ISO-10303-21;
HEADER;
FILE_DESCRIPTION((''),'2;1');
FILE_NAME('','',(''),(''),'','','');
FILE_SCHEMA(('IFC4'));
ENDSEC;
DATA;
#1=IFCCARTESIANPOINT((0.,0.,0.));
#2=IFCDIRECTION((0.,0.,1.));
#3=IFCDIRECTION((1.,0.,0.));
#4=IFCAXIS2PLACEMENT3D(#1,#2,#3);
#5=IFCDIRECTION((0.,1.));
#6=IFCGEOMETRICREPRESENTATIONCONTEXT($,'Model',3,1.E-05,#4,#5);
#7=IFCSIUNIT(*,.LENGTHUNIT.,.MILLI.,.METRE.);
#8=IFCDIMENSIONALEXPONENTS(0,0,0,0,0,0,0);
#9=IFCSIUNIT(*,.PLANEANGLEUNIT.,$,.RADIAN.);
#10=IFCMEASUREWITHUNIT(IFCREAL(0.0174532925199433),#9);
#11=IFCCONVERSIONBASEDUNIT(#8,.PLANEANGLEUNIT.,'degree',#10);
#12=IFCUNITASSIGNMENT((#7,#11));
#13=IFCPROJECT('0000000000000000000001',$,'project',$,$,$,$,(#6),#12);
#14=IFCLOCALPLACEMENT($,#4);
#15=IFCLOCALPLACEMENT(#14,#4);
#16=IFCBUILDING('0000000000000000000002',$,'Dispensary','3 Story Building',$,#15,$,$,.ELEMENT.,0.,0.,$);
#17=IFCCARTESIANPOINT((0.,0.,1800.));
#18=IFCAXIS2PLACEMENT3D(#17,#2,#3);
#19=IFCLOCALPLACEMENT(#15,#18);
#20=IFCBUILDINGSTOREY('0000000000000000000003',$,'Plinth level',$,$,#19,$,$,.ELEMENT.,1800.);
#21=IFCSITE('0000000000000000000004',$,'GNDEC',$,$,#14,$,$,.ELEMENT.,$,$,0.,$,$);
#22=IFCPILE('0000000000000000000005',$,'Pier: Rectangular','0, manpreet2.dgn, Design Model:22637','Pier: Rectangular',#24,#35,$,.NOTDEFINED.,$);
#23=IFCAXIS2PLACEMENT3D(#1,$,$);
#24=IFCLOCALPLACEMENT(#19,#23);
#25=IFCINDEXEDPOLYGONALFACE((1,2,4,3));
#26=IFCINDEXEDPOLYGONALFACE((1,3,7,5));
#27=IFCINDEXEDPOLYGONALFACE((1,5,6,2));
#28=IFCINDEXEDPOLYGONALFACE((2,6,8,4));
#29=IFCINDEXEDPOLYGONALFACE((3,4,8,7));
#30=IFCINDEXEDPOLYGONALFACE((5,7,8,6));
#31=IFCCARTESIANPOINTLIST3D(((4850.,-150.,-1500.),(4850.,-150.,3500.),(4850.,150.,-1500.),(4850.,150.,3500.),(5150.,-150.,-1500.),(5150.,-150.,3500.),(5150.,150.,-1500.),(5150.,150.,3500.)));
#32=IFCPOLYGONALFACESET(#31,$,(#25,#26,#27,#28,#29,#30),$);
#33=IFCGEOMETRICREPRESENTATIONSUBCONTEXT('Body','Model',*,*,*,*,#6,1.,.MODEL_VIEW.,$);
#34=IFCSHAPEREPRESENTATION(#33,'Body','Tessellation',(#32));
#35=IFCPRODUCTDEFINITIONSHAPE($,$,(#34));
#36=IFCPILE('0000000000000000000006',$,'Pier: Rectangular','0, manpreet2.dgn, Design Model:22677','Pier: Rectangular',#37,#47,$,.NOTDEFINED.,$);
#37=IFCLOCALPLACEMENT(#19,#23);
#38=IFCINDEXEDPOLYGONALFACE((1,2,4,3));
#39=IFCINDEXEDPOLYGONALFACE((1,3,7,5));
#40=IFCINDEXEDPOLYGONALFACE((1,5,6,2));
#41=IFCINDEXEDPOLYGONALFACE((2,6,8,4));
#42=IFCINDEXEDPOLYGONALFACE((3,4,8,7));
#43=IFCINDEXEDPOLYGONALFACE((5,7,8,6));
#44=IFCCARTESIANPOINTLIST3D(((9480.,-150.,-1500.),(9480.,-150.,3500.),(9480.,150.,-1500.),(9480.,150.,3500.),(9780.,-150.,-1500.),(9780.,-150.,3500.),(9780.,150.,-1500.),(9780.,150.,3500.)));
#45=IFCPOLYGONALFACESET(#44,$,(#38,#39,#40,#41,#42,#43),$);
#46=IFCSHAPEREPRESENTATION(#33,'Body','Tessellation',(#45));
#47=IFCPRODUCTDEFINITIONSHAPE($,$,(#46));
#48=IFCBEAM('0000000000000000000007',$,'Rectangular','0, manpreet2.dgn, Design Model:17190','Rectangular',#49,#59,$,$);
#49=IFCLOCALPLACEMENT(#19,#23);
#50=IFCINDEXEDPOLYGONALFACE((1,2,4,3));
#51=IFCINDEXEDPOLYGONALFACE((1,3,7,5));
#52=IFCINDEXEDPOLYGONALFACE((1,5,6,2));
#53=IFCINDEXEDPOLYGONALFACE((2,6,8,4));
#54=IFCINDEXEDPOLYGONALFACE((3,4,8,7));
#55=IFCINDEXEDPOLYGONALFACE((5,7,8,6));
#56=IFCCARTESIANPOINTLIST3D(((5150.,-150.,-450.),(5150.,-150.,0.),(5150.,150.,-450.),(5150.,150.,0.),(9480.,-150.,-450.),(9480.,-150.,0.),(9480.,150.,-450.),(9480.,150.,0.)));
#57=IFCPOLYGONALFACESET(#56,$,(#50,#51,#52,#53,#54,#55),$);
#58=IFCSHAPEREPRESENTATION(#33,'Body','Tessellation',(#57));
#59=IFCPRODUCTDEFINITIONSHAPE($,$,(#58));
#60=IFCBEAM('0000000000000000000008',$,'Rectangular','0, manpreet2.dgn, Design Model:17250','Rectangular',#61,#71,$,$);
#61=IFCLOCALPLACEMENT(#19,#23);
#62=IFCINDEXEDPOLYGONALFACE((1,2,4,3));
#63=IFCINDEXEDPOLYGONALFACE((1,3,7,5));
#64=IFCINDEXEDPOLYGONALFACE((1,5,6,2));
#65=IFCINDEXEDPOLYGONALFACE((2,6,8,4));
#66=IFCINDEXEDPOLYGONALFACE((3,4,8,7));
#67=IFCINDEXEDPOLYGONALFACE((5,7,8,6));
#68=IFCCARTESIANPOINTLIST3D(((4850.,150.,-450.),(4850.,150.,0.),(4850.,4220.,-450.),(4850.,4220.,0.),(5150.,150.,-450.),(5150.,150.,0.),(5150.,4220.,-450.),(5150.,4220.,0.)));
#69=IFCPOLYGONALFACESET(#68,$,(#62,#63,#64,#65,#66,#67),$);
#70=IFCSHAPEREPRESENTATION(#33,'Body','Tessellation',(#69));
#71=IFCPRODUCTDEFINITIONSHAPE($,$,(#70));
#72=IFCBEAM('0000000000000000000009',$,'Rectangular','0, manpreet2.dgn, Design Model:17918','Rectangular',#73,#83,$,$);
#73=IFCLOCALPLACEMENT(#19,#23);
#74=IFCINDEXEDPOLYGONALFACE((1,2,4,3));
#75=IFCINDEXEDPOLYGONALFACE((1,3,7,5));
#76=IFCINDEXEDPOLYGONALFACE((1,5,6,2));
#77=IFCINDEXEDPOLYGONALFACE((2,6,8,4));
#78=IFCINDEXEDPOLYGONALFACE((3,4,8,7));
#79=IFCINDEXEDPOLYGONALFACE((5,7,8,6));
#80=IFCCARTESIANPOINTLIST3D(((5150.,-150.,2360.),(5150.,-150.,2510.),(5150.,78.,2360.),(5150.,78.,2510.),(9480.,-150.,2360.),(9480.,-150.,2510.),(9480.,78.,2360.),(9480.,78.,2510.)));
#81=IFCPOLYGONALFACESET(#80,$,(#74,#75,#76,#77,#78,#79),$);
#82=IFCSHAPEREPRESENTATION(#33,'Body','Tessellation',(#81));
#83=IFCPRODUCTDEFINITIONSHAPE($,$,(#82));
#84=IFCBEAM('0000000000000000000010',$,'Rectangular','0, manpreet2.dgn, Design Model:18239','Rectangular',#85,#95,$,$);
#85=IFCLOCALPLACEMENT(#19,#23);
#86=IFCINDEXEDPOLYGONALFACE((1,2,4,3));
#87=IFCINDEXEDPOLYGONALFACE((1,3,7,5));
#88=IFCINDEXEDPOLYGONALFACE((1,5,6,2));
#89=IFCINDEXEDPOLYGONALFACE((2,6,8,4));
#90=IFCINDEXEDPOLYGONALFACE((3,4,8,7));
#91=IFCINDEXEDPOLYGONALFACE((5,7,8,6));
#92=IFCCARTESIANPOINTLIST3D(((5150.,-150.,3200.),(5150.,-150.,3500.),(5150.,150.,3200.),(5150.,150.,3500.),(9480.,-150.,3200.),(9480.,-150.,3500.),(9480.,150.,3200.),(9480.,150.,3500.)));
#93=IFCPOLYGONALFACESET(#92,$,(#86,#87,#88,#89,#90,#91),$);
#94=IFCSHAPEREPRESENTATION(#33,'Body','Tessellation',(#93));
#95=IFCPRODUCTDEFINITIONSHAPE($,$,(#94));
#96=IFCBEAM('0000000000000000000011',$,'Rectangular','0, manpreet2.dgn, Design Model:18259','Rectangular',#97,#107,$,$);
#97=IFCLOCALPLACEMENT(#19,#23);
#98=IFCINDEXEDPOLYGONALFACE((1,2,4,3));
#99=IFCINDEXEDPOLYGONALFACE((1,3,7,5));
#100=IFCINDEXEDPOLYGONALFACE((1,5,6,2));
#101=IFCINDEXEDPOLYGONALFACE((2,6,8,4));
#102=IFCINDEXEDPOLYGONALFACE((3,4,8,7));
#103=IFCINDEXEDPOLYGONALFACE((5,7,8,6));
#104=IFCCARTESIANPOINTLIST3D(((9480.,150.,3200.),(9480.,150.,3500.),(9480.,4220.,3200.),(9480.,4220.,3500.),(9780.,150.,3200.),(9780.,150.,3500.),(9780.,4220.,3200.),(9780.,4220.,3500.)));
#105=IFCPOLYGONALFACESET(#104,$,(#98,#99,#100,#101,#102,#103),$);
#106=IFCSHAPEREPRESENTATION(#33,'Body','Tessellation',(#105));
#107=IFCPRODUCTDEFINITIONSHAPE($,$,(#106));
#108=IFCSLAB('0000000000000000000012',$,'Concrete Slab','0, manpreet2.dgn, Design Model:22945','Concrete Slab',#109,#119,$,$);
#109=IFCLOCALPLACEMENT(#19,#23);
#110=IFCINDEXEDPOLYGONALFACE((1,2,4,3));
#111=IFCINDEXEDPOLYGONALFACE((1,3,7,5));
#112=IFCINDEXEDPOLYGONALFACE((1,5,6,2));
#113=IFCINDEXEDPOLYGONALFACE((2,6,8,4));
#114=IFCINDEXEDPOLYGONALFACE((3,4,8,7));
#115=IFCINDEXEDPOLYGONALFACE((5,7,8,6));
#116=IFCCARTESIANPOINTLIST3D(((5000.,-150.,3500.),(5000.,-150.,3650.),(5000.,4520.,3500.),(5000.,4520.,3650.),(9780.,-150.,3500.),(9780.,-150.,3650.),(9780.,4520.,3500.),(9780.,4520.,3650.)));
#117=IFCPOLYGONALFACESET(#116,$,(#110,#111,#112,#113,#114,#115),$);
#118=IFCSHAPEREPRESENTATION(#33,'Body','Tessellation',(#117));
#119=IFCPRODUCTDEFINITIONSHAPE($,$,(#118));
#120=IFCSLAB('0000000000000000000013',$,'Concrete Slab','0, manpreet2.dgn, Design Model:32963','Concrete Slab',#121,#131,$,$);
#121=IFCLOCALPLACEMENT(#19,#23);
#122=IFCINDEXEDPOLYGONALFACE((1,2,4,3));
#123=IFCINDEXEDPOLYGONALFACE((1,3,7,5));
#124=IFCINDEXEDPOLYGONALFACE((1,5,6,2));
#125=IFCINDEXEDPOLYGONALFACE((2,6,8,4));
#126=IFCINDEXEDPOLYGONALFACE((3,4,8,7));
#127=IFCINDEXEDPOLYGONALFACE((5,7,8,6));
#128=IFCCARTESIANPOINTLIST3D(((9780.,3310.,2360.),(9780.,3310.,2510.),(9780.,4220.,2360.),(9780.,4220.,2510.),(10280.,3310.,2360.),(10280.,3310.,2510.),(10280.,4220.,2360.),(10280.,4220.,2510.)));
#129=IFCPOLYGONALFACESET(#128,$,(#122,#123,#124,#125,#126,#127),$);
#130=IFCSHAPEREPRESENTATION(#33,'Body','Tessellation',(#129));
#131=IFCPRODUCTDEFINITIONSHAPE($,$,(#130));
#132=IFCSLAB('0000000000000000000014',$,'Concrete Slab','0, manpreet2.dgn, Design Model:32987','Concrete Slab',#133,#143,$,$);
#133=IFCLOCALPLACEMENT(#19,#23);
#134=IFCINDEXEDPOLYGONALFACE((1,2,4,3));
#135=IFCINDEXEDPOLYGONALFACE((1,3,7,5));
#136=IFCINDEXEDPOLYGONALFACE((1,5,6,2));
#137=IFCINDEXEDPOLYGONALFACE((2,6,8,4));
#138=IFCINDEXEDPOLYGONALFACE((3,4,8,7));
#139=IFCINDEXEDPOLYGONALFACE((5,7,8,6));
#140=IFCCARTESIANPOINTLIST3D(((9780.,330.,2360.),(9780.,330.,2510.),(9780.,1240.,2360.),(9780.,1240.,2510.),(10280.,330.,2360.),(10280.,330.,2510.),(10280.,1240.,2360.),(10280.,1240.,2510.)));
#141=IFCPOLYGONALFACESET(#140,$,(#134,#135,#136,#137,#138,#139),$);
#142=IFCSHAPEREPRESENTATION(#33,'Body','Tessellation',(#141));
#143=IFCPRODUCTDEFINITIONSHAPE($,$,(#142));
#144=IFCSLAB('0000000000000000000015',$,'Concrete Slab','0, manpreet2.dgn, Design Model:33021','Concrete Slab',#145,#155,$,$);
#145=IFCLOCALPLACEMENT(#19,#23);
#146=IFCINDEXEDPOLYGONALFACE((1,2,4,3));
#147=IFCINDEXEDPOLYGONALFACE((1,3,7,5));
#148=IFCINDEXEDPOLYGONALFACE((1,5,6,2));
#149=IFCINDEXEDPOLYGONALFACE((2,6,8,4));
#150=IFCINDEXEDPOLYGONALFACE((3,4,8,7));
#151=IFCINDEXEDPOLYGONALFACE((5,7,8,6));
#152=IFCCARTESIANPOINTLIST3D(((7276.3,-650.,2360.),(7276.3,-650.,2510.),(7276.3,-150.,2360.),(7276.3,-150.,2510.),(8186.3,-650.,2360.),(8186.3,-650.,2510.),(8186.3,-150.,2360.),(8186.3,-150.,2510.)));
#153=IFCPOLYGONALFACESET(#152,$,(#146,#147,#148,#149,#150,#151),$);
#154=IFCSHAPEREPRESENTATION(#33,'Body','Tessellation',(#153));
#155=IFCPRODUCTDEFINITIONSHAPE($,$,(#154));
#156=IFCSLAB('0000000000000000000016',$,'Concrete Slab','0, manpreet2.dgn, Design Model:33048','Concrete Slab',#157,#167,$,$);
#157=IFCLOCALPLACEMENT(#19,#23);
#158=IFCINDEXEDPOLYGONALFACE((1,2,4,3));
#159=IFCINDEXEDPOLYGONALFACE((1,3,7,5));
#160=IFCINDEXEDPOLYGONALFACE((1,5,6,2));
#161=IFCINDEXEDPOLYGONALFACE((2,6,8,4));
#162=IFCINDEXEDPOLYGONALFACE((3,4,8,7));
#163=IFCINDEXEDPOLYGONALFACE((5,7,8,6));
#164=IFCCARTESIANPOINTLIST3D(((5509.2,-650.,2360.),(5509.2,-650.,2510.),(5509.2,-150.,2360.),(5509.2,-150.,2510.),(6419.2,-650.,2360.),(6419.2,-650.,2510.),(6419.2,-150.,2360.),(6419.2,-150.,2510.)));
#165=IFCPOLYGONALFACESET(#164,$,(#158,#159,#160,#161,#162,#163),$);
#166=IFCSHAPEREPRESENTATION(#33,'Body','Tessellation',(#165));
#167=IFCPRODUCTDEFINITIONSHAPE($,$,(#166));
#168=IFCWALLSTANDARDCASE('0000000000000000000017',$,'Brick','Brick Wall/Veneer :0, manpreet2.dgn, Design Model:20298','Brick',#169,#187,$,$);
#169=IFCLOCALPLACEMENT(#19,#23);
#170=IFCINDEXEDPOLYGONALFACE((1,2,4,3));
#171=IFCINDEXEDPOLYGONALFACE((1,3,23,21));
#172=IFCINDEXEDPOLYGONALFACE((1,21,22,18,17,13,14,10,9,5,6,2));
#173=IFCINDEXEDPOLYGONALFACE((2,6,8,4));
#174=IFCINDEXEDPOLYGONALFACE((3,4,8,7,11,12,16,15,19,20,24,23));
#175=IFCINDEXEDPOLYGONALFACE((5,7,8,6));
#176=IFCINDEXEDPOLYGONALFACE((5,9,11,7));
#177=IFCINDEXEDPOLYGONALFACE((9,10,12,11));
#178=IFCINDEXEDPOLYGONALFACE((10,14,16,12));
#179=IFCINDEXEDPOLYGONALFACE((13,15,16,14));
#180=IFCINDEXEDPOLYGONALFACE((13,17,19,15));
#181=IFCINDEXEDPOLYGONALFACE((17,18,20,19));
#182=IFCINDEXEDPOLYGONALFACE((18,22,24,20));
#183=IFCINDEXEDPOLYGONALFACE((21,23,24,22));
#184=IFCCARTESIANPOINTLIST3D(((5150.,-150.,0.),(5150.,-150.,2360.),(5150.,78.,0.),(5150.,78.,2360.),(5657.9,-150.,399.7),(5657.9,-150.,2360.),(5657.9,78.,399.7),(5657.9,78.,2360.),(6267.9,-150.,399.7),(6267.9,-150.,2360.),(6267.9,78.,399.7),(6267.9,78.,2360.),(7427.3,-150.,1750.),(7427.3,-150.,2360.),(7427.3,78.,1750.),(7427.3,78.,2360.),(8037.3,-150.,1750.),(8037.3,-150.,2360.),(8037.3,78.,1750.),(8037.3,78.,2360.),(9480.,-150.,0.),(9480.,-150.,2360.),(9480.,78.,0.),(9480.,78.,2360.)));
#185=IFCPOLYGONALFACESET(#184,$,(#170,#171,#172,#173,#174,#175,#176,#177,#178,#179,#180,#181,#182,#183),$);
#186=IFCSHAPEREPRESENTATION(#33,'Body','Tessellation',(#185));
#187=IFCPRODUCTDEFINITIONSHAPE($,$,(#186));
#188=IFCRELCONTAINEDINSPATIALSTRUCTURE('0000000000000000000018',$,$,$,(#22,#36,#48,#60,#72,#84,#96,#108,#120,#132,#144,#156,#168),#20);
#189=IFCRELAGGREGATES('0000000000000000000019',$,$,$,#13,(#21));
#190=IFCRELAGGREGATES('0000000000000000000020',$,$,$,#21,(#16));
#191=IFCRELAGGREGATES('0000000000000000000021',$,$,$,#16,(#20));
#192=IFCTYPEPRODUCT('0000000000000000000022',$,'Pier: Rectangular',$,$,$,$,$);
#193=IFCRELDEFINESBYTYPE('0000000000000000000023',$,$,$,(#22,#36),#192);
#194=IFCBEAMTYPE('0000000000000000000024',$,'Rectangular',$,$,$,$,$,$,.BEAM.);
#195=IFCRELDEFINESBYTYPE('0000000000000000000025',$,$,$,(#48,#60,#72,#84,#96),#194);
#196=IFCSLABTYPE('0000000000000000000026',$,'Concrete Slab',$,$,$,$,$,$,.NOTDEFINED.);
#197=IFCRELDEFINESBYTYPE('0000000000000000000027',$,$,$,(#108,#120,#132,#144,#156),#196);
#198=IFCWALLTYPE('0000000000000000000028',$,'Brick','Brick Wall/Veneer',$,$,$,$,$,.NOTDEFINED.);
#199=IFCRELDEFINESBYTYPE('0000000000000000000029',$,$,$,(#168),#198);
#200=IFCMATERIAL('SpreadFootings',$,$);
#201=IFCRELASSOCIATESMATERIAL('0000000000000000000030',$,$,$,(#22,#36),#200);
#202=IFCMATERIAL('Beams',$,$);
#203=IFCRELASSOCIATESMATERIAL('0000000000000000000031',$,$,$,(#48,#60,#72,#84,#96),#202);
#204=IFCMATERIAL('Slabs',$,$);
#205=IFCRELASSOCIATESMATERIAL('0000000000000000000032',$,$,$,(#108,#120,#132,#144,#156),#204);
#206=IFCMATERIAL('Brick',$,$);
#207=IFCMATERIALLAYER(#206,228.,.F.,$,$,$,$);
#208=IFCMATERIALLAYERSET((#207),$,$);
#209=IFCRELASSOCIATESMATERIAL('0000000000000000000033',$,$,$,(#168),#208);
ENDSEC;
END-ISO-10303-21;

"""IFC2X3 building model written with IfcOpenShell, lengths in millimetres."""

from ifc_helpers import new_model, entity, si_unit, converted_unit, direction, frame, frame_2d, origin_with_axes, place, context, subcontext, project, spatial, rectangle, extrude, material, layer, layer_set, layer_usage, type_object, element, save


model = new_model("IFC2X3")

# Units and contexts
model_context = context("Model", 3, precision=1e-05, world=origin_with_axes(), true_north=direction((0.0, 1.0)))
body_context = subcontext(model_context, "Body", "Model", "MODEL_VIEW", scale=1.0)
ifc_project = project(units=[si_unit("LENGTHUNIT", "METRE", prefix="MILLI"), converted_unit("PLANEANGLEUNIT", "degree", entity("IfcReal", 0.0174532925199433), si_unit("PLANEANGLEUNIT", "RADIAN"), dimensions=[0, 0, 0, 0, 0, 0, 0])], contexts=[model_context])

# Site, building, storey
site_placement = place(None, origin_with_axes())
site = spatial("IfcSite", under=ifc_project, at=site_placement, Name="GNDEC", CompositionType="ELEMENT", RefElevation=0.0)
building_placement = place(site_placement, origin_with_axes())
building = spatial("IfcBuilding", under=site, at=building_placement, Name="Dispensary", Description="3 Story Building", CompositionType="ELEMENT", ElevationOfRefHeight=0.0, ElevationOfTerrain=0.0)
storey_placement = place(building_placement, frame((0.0, 0.0, 1800.0), z_axis=(0.0, 0.0, 1.0), x_axis=(1.0, 0.0, 0.0)))
storey = spatial("IfcBuildingStorey", under=building, at=storey_placement, Name="Plinth level", CompositionType="ELEMENT", Elevation=1800.0)

# Piles
ifc_material_1 = material(Name="SpreadFootings")
type_product = type_object("IfcTypeProduct", Name="Pier: Rectangular")
for number, where, z_axis, x_axis, name, description in (
    (1, (4850.0, 150.0, -1500.0), (0.0, 0.0, 1.0), (0.0, -1.0, 0.0), "Pier: Rectangular", "0, manpreet2.dgn, Design Model:22637"),
    (2, (9480.0, 150.0, -1500.0), (0.0, 0.0, 1.0), (0.0, -1.0, 0.0), "Pier: Rectangular", "0, manpreet2.dgn, Design Model:22677"),
):
    element("IfcPile", number, at=place(storey_placement, frame(where, z_axis=z_axis, x_axis=x_axis)), inside=storey, type_object=type_product, material=ifc_material_1, Name=name, Description=description, ObjectType="Pier: Rectangular", PredefinedType="NOTDEFINED", context=body_context, shape_type="SweptSolid", body=[
        extrude(rectangle(XDim=300.0, YDim=300.0, at=frame_2d((150.0, 150.0), x_axis=(0.0, 1.0))), origin_with_axes(), (0.0, 0.0, 1.0), 5000.0),
    ])

# Beams
ifc_material_2 = material(Name="Beams")
beam_type = type_object("IfcBeamType", Name="Rectangular", PredefinedType="BEAM")
beam_1_placement = place(storey_placement, frame((9480.0, -150.0, -450.0), z_axis=(-1.0, 0.0, 0.0), x_axis=(0.0, 0.0, 1.0)))
element("IfcBeam", 3, at=beam_1_placement, inside=storey, type_object=beam_type, material=ifc_material_2, Name="Rectangular", Description="0, manpreet2.dgn, Design Model:17190", ObjectType="Rectangular", context=body_context, shape_type="SweptSolid", body=[
    extrude(rectangle(XDim=300.0, YDim=450.0, at=frame_2d((225.0, 150.0), x_axis=(0.0, 1.0))), origin_with_axes(), (0.0, 0.0, 1.0), 4330.0),
])
beam_2_placement = place(storey_placement, frame((4850.0, 150.0, -450.0), z_axis=(0.0, 1.0, 0.0), x_axis=(0.0, 0.0, 1.0)))
element("IfcBeam", 4, at=beam_2_placement, inside=storey, type_object=beam_type, material=ifc_material_2, Name="Rectangular", Description="0, manpreet2.dgn, Design Model:17250", ObjectType="Rectangular", context=body_context, shape_type="SweptSolid", body=[
    extrude(rectangle(XDim=300.0, YDim=450.0, at=frame_2d((225.0, 150.0), x_axis=(0.0, 1.0))), origin_with_axes(), (0.0, 0.0, 1.0), 4070.0),
])
beam_3_placement = place(storey_placement, frame((9480.0, 78.0, 2360.0), z_axis=(-1.0, 0.0, 0.0), x_axis=(0.0, -1.0, 0.0)))
element("IfcBeam", 5, at=beam_3_placement, inside=storey, type_object=beam_type, material=ifc_material_2, Name="Rectangular", Description="0, manpreet2.dgn, Design Model:17918", ObjectType="Rectangular", context=body_context, shape_type="SweptSolid", body=[
    extrude(rectangle(XDim=150.0, YDim=228.0, at=frame_2d((114.0, 75.0), x_axis=(0.0, 1.0))), origin_with_axes(), (0.0, 0.0, 1.0), 4330.0),
])
beam_4_placement = place(storey_placement, frame((5150.0, -150.0, 3200.0), z_axis=(1.0, 0.0, 0.0), x_axis=(0.0, 1.0, 0.0)))
element("IfcBeam", 6, at=beam_4_placement, inside=storey, type_object=beam_type, material=ifc_material_2, Name="Rectangular", Description="0, manpreet2.dgn, Design Model:18239", ObjectType="Rectangular", context=body_context, shape_type="SweptSolid", body=[
    extrude(rectangle(XDim=300.0, YDim=300.0, at=frame_2d((150.0, 150.0), x_axis=(0.0, 1.0))), origin_with_axes(), (0.0, 0.0, 1.0), 4330.0),
])
beam_5_placement = place(storey_placement, frame((9780.0, 150.0, 3200.0), z_axis=(0.0, 1.0, 0.0), x_axis=(-1.0, 0.0, 0.0)))
element("IfcBeam", 7, at=beam_5_placement, inside=storey, type_object=beam_type, material=ifc_material_2, Name="Rectangular", Description="0, manpreet2.dgn, Design Model:18259", ObjectType="Rectangular", context=body_context, shape_type="SweptSolid", body=[
    extrude(rectangle(XDim=300.0, YDim=300.0, at=frame_2d((150.0, 150.0), x_axis=(0.0, 1.0))), origin_with_axes(), (0.0, 0.0, 1.0), 4070.0),
])

# Slabs
ifc_material_3 = material(Name="Slabs")
slab_type = type_object("IfcSlabType", Name="Concrete Slab", PredefinedType="NOTDEFINED")
slab_1_placement = place(storey_placement, frame((5000.0, -150.0, 3500.0), z_axis=(0.0, 0.0, 1.0), x_axis=(1.0, 0.0, 0.0)))
element("IfcSlab", 8, at=slab_1_placement, inside=storey, type_object=slab_type, material=ifc_material_3, Name="Concrete Slab", Description="0, manpreet2.dgn, Design Model:22945", ObjectType="Concrete Slab", context=body_context, shape_type="SweptSolid", body=[
    extrude(rectangle(XDim=4780.0, YDim=4670.0, at=frame_2d((2390.0, 2335.0), x_axis=(1.0, 0.0))), origin_with_axes(), (0.0, 0.0, 1.0), 150.0),
])
for number, where, z_axis, x_axis, name, description in (
    (9, (9780.0, 4070.0, 2510.0), (0.0, 0.0, -1.0), (0.0, 1.0, 0.0), "Concrete Slab", "0, manpreet2.dgn, Design Model:32963"),
    (10, (9780.0, 1090.0, 2510.0), (0.0, 0.0, -1.0), (0.0, 1.0, 0.0), "Concrete Slab", "0, manpreet2.dgn, Design Model:32987"),
):
    element("IfcSlab", number, at=place(storey_placement, frame(where, z_axis=z_axis, x_axis=x_axis)), inside=storey, type_object=slab_type, material=ifc_material_3, Name=name, Description=description, ObjectType="Concrete Slab", context=body_context, shape_type="SweptSolid", body=[
        extrude(rectangle(XDim=500.0, YDim=910.0, at=frame_2d((-305.0, 250.0), x_axis=(0.0, 1.0))), origin_with_axes(), (0.0, 0.0, 1.0), 150.0),
    ])
slab_2_placement = place(storey_placement, frame((8037.3, -150.0, 2510.0), z_axis=(0.0, 0.0, -1.0), x_axis=(-1.0, 0.0, 0.0)))
element("IfcSlab", 11, at=slab_2_placement, inside=storey, type_object=slab_type, material=ifc_material_3, Name="Concrete Slab", Description="0, manpreet2.dgn, Design Model:33021", ObjectType="Concrete Slab", context=body_context, shape_type="SweptSolid", body=[
    extrude(rectangle(XDim=500.0, YDim=910.0, at=frame_2d((306.0, -250.0), x_axis=(0.0, -1.0))), origin_with_axes(), (0.0, 0.0, 1.0), 150.0),
])
slab_3_placement = place(storey_placement, frame((6269.2, -150.0, 2510.0), z_axis=(0.0, 0.0, -1.0), x_axis=(1.0, 0.0, 0.0)))
element("IfcSlab", 12, at=slab_3_placement, inside=storey, type_object=slab_type, material=ifc_material_3, Name="Concrete Slab", Description="0, manpreet2.dgn, Design Model:33048", ObjectType="Concrete Slab", context=body_context, shape_type="SweptSolid", body=[
    extrude(rectangle(XDim=500.0, YDim=910.0, at=frame_2d((-305.0, 250.0), x_axis=(0.0, 1.0))), origin_with_axes(), (0.0, 0.0, 1.0), 150.0),
])

# Wall, openings
ifc_material_4 = material(Name="Brick")
ifc_layer = layer(ifc_material_4, 228.0, ventilated=False)
ifc_layer_set = layer_set([ifc_layer])
ifc_layer_usage = layer_usage(ifc_layer_set, "AXIS2", "POSITIVE", 0.0)
wall_type = type_object("IfcWallType", Name="Brick", Description="Brick Wall/Veneer", PredefinedType="NOTDEFINED")
wall_1_placement = place(storey_placement, frame((9480.0, -150.0, 0.0), z_axis=(0.0, 0.0, 1.0), x_axis=(-1.0, 0.0, 0.0)))
wall_1 = element("IfcWallStandardCase", 13, at=wall_1_placement, inside=storey, type_object=wall_type, material=ifc_layer_usage, Name="Brick", Description="Brick Wall/Veneer :0, manpreet2.dgn, Design Model:20298", ObjectType="Brick", context=body_context, shape_type="SweptSolid", body=[
    extrude(rectangle(XDim=4330.0, YDim=228.0, at=frame_2d((2165.0, -114.0), x_axis=(-1.0, 0.0))), origin_with_axes(), (0.0, 0.0, 1.0), 2360.0),
])
opening_1_placement = place(wall_1_placement, frame((3212.1, -228.0, 399.7), z_axis=(0.0, 0.0, 1.0), x_axis=(1.0, 0.0, 0.0)))
element("IfcOpeningElement", 14, at=opening_1_placement, cuts=wall_1, ObjectType="Opening", context=body_context, shape_type="SweptSolid", body=[
    extrude(rectangle(XDim=2720.0, YDim=610.0, at=frame_2d((-305.0, 1360.0), x_axis=(0.0, -1.0))), frame((0.0, 0.0, 0.0), z_axis=(0.0, 1.0, 0.0), x_axis=(-1.0, 0.0, 0.0)), (0.0, 0.0, 1.0), 228.0),
])
opening_2_placement = place(wall_1_placement, frame((1442.7, -228.0, 1750.0), z_axis=(0.0, 0.0, 1.0), x_axis=(1.0, 0.0, 0.0)))
element("IfcOpeningElement", 15, at=opening_2_placement, cuts=wall_1, ObjectType="Opening", context=body_context, shape_type="SweptSolid", body=[
    extrude(rectangle(XDim=1370.0, YDim=610.0, at=frame_2d((-305.0, 685.0), x_axis=(0.0, -1.0))), frame((0.0, 0.0, 0.0), z_axis=(0.0, 1.0, 0.0), x_axis=(-1.0, 0.0, 0.0)), (0.0, 0.0, 1.0), 228.0),
])

save(model, "model.ifc")
